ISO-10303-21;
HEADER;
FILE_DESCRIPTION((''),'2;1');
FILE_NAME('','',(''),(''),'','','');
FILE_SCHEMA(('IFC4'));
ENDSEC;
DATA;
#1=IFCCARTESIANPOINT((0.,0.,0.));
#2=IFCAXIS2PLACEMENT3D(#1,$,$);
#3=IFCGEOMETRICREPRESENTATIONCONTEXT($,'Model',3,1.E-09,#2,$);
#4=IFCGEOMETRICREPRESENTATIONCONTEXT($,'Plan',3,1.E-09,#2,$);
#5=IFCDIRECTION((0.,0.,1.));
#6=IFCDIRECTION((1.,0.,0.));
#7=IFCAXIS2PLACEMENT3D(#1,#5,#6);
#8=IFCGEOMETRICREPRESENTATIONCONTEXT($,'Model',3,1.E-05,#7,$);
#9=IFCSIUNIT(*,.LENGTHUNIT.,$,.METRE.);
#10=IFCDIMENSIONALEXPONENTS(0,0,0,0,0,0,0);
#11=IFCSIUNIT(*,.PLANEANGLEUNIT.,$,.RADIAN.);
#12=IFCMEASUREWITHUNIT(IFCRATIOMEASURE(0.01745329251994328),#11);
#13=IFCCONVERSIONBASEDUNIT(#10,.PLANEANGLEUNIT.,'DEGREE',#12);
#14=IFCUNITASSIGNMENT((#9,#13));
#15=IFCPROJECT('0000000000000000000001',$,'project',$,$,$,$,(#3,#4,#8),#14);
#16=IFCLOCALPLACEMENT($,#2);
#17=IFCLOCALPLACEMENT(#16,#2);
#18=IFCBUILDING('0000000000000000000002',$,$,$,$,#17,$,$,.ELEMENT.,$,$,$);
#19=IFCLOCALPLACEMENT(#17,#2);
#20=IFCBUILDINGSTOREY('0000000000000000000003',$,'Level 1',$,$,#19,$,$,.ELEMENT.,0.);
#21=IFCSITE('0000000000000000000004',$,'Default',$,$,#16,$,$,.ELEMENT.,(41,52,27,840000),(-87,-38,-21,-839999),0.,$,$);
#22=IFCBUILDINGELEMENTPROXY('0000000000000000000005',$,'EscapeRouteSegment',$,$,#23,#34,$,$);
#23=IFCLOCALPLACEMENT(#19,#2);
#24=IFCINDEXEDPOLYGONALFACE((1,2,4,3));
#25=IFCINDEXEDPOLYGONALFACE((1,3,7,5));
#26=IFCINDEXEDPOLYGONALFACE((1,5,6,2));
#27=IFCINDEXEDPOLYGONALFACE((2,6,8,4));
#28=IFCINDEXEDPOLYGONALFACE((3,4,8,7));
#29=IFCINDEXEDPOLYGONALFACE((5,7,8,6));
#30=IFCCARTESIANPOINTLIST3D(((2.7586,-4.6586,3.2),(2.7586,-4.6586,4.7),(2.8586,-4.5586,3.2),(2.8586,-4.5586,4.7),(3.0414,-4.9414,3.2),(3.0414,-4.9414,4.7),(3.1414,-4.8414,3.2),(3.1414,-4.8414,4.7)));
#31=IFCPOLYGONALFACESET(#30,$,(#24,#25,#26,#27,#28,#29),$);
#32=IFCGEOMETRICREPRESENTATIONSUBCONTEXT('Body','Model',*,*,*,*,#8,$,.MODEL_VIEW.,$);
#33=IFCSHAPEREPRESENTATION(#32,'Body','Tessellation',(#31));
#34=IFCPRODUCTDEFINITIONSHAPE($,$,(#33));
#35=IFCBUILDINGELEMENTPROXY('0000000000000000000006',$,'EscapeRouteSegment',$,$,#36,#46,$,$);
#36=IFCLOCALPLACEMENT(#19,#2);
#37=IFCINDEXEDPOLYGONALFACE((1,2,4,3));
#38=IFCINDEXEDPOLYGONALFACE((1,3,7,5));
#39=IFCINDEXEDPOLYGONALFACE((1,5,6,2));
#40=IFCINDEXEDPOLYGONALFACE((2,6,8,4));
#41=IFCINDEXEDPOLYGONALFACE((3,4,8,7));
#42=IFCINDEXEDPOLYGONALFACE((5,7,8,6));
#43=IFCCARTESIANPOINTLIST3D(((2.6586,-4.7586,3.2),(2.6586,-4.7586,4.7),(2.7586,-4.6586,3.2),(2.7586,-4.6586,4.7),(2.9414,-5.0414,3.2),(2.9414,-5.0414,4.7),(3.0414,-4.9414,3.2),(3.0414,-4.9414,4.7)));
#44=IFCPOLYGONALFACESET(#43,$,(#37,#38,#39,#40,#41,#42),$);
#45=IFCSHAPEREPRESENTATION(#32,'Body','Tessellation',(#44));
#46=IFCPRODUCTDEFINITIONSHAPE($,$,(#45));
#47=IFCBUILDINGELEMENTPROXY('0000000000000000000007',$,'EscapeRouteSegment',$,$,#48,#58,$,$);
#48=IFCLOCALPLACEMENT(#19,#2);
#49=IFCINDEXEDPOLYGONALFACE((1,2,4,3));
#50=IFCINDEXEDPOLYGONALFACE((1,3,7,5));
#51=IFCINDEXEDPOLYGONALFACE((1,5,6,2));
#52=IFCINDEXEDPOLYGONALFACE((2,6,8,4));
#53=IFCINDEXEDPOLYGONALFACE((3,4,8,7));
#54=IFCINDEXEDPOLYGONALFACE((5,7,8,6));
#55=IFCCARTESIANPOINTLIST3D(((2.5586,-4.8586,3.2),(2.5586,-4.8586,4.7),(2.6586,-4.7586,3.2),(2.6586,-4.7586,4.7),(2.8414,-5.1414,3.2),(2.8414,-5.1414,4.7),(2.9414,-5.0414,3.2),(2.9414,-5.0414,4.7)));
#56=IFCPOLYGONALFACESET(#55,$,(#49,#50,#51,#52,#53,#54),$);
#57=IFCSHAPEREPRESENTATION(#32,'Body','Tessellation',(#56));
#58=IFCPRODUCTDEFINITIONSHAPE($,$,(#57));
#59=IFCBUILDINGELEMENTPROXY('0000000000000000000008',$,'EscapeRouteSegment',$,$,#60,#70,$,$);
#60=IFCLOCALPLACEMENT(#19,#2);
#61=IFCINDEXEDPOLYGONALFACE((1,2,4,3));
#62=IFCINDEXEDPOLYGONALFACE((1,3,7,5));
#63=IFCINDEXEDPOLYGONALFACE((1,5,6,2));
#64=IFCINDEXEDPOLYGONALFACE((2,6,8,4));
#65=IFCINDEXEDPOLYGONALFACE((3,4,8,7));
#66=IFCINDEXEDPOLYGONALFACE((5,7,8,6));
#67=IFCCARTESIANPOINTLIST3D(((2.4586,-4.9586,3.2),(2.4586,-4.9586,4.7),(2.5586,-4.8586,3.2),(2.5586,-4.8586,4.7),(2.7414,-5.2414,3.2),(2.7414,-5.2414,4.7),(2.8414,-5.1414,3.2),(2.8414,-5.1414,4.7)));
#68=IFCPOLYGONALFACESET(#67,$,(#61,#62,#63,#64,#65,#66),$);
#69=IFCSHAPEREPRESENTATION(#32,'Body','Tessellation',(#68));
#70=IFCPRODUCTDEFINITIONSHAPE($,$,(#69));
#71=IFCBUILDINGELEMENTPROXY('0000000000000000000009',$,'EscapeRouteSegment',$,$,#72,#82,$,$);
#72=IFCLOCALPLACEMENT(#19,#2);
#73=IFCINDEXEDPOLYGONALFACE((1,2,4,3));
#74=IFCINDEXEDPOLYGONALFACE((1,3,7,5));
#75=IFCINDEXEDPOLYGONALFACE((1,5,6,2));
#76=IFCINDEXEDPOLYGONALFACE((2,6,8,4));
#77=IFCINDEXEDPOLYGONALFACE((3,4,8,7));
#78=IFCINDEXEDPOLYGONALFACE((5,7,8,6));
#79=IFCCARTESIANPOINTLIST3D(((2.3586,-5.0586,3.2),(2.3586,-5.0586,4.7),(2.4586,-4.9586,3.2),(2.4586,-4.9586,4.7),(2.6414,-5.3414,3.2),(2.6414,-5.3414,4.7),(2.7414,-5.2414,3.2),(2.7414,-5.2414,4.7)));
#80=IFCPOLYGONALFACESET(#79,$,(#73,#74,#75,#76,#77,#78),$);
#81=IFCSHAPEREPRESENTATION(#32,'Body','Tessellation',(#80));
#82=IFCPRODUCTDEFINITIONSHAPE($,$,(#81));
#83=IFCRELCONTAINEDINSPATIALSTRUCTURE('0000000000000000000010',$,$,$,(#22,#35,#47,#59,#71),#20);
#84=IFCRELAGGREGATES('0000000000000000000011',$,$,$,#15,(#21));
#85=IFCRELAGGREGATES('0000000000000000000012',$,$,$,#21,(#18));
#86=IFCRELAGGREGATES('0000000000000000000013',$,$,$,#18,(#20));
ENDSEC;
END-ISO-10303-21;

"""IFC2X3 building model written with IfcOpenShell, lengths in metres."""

from ifc_helpers import new_model, entity, si_unit, converted_unit, frame, origin, origin_with_axes, place, context, subcontext, project, spatial, polyline, outline, extrude, element, save


model = new_model("IFC2X3")

# Units and contexts
model_context_1 = context("Model", 3, precision=1e-09, world=origin())
plan_context = context("Plan", 3, precision=1e-09, world=origin())
model_context_2 = context("Model", 3, precision=1e-05, world=origin_with_axes())
body_context = subcontext(model_context_2, "Body", "Model", "MODEL_VIEW")
ifc_project = project(units=[si_unit("LENGTHUNIT", "METRE"), converted_unit("PLANEANGLEUNIT", "DEGREE", entity("IfcRatioMeasure", 0.01745329251994328), si_unit("PLANEANGLEUNIT", "RADIAN"), dimensions=[0, 0, 0, 0, 0, 0, 0])], contexts=[model_context_1, plan_context, model_context_2])

# Site, building, storey
site_placement = place(None, origin())
site = spatial("IfcSite", under=ifc_project, at=site_placement, Name="Default", CompositionType="ELEMENT", RefLatitude=(41, 52, 27, 840000), RefLongitude=(-87, -38, -21, -839999), RefElevation=0.0)
building_placement = place(site_placement, origin())
building = spatial("IfcBuilding", under=site, at=building_placement, CompositionType="ELEMENT")
storey_placement = place(building_placement, origin())
storey = spatial("IfcBuildingStorey", under=building, at=storey_placement, Name="Level 1", CompositionType="ELEMENT", Elevation=0.0)

# Building element proxies
proxy_1_placement = place(storey_placement, frame((3.0, -4.7, 3.2), z_axis=(0.0, 0.0, 1.0), x_axis=(-0.707105, -0.707108, 0.0)))
element("IfcBuildingElementProxy", 1, at=proxy_1_placement, inside=storey, Name="EscapeRouteSegment", context=body_context, shape_type="SweptSolid", body=[
    extrude(outline(polyline([(0.0, -0.2), (0.0, 0.2), (0.1414, 0.2), (0.1414, -0.2), (0.0, -0.2)])), origin_with_axes(), (0.0, 0.0, 1.0), 1.5),
])
proxy_2_placement = place(storey_placement, frame((2.9, -4.8, 3.2), z_axis=(0.0, 0.0, 1.0), x_axis=(-0.707108, -0.707106, 0.0)))
element("IfcBuildingElementProxy", 2, at=proxy_2_placement, inside=storey, Name="EscapeRouteSegment", context=body_context, shape_type="SweptSolid", body=[
    extrude(outline(polyline([(0.0, -0.2), (0.0, 0.2), (0.1414, 0.2), (0.1414, -0.2), (0.0, -0.2)])), origin_with_axes(), (0.0, 0.0, 1.0), 1.5),
])
proxy_3_placement = place(storey_placement, frame((2.8, -4.9, 3.2), z_axis=(0.0, 0.0, 1.0), x_axis=(-0.707107, -0.707107, 0.0)))
element("IfcBuildingElementProxy", 3, at=proxy_3_placement, inside=storey, Name="EscapeRouteSegment", context=body_context, shape_type="SweptSolid", body=[
    extrude(outline(polyline([(0.0, -0.2), (0.0, 0.2), (0.1414, 0.2), (0.1414, -0.2), (0.0, -0.2)])), origin_with_axes(), (0.0, 0.0, 1.0), 1.5),
])
proxy_4_placement = place(storey_placement, frame((2.7, -5.0, 3.2), z_axis=(0.0, 0.0, 1.0), x_axis=(-0.707108, -0.707106, 0.0)))
element("IfcBuildingElementProxy", 4, at=proxy_4_placement, inside=storey, Name="EscapeRouteSegment", context=body_context, shape_type="SweptSolid", body=[
    extrude(outline(polyline([(0.0, -0.2), (0.0, 0.2), (0.1414, 0.2), (0.1414, -0.2), (0.0, -0.2)])), origin_with_axes(), (0.0, 0.0, 1.0), 1.5),
])
proxy_5_placement = place(storey_placement, frame((2.6, -5.1, 3.2), z_axis=(0.0, 0.0, 1.0), x_axis=(-0.707107, -0.707107, 0.0)))
element("IfcBuildingElementProxy", 5, at=proxy_5_placement, inside=storey, Name="EscapeRouteSegment", context=body_context, shape_type="SweptSolid", body=[
    extrude(outline(polyline([(0.0, -0.2), (0.0, 0.2), (0.1414, 0.2), (0.1414, -0.2), (0.0, -0.2)])), origin_with_axes(), (0.0, 0.0, 1.0), 1.5),
])

save(model, "model.ifc")
